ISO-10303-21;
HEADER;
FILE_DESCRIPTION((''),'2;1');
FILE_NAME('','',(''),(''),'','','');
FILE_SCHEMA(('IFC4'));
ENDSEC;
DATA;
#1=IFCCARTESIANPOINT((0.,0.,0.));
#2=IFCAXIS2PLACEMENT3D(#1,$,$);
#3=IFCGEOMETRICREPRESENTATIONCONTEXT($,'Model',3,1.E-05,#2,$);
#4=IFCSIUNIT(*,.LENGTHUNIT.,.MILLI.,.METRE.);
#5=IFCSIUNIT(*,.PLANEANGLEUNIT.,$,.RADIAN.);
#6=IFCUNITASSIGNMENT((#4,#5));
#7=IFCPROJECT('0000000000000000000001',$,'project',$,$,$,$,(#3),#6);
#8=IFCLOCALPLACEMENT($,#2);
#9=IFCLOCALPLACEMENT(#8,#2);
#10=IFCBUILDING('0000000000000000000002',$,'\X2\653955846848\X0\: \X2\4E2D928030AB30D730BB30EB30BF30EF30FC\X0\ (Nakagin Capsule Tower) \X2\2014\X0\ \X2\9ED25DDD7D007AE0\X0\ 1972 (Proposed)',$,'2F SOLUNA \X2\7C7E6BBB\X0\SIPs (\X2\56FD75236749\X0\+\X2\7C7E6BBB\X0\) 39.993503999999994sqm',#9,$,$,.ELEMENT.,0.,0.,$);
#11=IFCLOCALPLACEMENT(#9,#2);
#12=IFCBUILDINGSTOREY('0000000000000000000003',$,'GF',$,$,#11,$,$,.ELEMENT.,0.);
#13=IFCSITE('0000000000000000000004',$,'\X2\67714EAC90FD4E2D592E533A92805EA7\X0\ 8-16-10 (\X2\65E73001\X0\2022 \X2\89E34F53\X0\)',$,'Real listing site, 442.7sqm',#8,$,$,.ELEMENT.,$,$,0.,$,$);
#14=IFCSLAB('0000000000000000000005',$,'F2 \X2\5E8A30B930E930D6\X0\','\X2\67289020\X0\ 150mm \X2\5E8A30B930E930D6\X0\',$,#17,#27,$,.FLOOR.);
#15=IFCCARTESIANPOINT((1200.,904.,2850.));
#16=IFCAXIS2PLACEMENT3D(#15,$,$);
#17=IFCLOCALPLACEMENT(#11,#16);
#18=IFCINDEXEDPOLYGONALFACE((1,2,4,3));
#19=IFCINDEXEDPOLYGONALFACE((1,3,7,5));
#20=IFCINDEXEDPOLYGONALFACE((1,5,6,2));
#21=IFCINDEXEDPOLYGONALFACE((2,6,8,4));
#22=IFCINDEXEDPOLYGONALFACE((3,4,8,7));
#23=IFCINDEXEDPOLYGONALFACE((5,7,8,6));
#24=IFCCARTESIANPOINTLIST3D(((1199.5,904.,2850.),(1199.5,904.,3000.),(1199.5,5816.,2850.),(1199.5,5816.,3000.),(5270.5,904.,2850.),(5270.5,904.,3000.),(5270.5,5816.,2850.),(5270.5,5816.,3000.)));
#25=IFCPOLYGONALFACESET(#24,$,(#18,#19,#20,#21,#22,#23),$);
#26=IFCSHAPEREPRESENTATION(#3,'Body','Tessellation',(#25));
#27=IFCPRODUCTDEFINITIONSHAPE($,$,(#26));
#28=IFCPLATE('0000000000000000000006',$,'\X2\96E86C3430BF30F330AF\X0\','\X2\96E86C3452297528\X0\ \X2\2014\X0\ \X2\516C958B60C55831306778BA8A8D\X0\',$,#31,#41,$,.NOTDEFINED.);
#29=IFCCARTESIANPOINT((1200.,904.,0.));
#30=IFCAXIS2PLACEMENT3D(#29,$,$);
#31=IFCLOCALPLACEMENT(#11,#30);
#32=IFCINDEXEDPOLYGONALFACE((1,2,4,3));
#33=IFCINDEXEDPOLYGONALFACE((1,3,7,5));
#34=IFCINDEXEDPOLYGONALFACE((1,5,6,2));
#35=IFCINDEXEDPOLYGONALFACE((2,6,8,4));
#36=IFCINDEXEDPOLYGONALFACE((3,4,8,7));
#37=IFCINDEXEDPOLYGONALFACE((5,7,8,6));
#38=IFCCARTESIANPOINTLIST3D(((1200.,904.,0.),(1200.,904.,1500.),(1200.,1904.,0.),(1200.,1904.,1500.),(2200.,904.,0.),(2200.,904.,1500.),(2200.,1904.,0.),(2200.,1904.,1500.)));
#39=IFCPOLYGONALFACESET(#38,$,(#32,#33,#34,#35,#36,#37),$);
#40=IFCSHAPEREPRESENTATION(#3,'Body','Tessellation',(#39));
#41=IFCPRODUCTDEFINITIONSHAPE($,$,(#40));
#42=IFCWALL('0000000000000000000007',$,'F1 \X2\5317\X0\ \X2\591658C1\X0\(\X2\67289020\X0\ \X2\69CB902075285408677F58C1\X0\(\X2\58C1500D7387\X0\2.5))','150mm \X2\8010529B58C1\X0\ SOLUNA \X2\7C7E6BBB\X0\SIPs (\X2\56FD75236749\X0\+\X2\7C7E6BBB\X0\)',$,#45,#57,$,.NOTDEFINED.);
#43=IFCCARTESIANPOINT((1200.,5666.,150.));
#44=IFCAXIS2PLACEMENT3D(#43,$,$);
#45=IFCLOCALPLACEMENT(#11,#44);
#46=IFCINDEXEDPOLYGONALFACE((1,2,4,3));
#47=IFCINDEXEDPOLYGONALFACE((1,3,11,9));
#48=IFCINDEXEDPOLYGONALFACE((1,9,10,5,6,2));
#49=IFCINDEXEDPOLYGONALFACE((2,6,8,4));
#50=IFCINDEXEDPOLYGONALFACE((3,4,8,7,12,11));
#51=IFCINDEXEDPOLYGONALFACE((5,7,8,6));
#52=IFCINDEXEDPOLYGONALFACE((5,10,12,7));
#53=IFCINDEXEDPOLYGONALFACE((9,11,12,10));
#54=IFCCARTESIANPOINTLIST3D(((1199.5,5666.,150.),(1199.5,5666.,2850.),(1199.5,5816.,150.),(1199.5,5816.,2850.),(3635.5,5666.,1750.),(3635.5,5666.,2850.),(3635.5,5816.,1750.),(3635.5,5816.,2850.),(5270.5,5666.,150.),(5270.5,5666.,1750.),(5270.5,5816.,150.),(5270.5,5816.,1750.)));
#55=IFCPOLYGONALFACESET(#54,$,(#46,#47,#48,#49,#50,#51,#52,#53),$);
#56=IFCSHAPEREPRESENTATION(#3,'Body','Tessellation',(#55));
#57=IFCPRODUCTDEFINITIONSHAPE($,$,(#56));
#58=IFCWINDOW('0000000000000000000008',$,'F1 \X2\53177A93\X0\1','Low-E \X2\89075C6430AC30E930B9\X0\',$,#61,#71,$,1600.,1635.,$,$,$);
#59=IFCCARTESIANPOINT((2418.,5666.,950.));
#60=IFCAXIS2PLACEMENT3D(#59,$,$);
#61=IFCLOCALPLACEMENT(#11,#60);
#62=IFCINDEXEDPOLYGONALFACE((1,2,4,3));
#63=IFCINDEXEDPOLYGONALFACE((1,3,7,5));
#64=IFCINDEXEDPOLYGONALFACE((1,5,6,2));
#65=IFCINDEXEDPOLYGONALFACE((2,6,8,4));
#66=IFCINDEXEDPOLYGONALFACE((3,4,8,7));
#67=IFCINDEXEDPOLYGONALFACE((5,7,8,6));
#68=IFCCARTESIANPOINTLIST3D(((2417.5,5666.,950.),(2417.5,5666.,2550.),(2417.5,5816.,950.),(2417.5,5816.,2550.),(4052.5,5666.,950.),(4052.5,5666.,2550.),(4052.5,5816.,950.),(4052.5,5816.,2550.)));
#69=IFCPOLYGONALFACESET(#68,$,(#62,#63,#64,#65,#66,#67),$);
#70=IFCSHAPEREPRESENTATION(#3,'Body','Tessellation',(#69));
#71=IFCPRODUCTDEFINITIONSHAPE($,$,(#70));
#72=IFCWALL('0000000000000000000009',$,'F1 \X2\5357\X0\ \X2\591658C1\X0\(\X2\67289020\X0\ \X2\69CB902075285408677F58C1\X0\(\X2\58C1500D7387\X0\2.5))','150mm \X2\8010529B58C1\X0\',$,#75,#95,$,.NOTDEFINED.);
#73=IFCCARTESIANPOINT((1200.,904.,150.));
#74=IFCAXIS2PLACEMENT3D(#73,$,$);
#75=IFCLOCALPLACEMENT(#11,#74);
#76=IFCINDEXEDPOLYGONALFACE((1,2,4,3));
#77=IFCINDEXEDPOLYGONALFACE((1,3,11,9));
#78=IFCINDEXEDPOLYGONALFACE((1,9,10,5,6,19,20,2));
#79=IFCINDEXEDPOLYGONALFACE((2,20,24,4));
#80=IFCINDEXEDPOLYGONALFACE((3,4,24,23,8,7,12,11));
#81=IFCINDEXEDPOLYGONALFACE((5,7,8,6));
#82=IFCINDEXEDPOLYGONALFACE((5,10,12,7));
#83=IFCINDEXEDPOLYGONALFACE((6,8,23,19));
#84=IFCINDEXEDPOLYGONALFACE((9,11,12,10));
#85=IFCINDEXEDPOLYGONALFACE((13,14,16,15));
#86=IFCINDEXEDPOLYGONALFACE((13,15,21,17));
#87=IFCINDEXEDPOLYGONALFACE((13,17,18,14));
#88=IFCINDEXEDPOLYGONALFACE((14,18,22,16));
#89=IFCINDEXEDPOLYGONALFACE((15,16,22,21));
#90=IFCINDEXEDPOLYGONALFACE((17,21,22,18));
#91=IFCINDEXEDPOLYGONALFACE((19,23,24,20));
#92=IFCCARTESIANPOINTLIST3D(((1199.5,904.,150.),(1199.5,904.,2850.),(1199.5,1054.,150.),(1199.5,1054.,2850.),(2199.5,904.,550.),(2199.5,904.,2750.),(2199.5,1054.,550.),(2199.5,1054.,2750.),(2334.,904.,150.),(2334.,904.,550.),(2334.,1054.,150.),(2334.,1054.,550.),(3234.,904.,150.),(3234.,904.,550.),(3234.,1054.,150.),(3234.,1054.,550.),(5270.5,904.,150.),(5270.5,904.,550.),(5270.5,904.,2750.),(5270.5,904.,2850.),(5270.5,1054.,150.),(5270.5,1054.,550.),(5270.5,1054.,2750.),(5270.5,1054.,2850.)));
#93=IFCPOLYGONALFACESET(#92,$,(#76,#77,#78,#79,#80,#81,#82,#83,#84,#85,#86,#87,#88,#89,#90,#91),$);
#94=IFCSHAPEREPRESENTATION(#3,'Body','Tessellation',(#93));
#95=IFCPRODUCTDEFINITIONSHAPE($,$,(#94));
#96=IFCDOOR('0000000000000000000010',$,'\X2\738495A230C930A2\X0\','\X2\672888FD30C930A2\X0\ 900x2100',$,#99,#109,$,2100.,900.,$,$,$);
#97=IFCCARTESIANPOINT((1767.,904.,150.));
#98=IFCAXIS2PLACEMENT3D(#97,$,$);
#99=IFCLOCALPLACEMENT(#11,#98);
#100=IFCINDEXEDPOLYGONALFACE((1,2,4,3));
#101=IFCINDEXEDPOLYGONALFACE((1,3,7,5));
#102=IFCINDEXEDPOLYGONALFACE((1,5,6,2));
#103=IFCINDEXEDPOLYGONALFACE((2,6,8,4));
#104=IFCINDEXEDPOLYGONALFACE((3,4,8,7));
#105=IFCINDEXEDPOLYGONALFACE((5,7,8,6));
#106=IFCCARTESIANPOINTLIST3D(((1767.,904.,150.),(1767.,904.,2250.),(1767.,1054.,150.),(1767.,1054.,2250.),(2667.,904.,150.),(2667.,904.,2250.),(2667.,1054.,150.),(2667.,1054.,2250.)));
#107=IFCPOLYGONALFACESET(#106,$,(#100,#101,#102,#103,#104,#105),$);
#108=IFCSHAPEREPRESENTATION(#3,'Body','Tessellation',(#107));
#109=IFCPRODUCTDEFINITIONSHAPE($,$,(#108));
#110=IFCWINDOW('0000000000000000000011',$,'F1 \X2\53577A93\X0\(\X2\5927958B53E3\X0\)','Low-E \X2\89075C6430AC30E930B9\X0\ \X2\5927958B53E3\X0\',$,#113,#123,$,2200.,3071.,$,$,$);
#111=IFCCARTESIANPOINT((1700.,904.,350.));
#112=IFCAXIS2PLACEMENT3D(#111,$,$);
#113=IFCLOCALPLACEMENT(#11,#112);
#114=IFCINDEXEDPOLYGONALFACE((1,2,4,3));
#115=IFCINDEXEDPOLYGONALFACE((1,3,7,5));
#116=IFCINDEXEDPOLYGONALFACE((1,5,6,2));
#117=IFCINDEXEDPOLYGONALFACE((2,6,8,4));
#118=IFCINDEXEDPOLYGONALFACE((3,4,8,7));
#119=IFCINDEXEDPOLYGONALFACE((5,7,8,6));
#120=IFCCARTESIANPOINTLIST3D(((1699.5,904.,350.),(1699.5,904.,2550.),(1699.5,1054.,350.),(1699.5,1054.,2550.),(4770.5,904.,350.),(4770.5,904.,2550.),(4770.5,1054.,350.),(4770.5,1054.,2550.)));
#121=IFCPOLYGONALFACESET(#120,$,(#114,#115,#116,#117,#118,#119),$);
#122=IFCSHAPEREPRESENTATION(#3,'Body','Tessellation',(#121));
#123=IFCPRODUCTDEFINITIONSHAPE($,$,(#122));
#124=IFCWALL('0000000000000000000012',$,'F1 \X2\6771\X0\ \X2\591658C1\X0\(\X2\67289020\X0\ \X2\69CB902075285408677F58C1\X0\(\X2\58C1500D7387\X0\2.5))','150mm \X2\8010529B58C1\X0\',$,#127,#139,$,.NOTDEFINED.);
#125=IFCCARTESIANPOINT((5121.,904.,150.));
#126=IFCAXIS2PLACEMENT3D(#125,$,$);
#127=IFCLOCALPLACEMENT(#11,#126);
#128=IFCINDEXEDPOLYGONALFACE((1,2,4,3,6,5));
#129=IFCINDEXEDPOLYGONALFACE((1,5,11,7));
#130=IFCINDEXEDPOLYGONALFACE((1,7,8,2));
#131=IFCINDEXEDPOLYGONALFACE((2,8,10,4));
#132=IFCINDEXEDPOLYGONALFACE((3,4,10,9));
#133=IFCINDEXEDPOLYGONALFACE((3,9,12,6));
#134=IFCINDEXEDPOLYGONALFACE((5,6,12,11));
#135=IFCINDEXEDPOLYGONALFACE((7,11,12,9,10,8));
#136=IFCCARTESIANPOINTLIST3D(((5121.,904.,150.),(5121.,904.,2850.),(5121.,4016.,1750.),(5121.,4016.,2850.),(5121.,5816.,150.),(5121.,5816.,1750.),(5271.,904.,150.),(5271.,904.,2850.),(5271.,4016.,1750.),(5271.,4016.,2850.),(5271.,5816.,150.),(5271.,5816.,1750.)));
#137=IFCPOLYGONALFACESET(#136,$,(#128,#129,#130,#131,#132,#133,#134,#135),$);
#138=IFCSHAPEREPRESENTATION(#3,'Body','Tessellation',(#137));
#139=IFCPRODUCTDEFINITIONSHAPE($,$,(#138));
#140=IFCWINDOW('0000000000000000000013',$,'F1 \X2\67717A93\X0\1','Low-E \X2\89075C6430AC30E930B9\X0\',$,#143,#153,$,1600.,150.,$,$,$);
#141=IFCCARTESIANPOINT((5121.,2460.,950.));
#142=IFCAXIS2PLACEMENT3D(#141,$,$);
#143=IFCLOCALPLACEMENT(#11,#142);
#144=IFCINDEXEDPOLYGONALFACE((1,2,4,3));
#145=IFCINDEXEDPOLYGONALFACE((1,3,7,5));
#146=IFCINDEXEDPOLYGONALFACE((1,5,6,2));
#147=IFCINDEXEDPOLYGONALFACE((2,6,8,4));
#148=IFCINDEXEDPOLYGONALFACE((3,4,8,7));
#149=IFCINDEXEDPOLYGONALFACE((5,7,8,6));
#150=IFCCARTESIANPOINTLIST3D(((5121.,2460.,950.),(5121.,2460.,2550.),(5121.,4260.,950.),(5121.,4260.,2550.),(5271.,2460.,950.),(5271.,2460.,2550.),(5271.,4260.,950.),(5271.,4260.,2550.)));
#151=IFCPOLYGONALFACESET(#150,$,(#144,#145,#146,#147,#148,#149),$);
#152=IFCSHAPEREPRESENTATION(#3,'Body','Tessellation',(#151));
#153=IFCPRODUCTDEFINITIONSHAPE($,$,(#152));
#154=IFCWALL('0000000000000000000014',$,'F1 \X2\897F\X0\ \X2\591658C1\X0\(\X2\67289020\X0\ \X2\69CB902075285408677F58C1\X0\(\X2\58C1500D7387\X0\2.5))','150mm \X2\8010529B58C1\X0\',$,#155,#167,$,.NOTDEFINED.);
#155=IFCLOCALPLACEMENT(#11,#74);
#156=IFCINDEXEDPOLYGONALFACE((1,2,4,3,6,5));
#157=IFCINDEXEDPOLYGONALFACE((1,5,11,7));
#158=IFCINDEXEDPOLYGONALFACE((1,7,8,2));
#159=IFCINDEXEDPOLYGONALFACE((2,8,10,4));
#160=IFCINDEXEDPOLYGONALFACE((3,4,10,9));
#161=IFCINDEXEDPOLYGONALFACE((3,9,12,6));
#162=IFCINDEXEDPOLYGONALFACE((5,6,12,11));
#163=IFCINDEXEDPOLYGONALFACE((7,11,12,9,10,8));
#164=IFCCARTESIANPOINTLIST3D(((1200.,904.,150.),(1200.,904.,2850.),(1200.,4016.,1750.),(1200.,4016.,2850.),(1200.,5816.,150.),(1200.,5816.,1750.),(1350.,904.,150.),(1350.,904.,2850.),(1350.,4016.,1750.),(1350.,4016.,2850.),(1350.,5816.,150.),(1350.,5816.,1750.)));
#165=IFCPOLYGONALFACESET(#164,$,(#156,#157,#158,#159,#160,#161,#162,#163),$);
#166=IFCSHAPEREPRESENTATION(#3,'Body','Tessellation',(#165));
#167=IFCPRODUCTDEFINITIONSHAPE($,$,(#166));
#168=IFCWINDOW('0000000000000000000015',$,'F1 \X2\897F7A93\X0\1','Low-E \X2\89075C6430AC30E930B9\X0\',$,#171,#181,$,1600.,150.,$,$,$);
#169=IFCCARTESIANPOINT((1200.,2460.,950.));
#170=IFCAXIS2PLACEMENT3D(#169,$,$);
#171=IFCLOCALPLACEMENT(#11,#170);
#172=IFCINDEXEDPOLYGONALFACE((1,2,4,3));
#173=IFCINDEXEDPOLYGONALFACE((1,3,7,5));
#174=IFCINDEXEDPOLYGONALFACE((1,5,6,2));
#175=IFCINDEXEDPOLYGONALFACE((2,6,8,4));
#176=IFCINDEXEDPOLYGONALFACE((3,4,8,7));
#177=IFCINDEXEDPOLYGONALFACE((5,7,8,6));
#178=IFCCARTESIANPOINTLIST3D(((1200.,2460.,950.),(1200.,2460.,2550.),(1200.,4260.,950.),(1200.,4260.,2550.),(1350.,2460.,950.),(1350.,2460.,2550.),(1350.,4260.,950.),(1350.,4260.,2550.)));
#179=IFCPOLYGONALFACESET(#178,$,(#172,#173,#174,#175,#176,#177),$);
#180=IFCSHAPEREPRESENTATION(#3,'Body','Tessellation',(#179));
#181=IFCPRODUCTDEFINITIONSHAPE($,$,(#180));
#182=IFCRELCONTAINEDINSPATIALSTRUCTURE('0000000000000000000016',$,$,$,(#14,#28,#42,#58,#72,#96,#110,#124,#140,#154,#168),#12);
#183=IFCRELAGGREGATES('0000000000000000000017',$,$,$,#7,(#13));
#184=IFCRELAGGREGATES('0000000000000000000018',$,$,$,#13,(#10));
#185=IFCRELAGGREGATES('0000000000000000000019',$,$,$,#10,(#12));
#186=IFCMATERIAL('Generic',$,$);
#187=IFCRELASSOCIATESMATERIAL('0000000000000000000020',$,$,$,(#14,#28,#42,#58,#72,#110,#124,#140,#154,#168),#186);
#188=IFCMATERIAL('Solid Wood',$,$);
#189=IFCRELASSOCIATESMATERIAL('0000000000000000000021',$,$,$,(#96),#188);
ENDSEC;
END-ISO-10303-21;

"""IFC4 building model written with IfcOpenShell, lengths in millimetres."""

from ifc_helpers import new_model, si_unit, frame, frame_2d, origin, place, context, project, spatial, rectangle, extrude, material, element, fill, save


model = new_model("IFC4")

# Units and contexts
model_context = context("Model", 3, precision=1e-05, world=origin())
ifc_project = project(units=[si_unit("LENGTHUNIT", "METRE", prefix="MILLI"), si_unit("PLANEANGLEUNIT", "RADIAN")], contexts=[model_context])

# Site, building, storey
site_placement = place(None, origin())
site = spatial("IfcSite", under=ifc_project, at=site_placement, Name="東京都中央区銀座 8-16-10 (旧、2022 解体)", ObjectType="Real listing site, 442.7sqm", CompositionType="ELEMENT", RefElevation=0.0)
building_placement = place(site_placement, origin())
building = spatial("IfcBuilding", under=site, at=building_placement, Name="改善案: 中銀カプセルタワー (Nakagin Capsule Tower) — 黒川紀章 1972 (Proposed)", ObjectType="2F SOLUNA 籾殻SIPs (国産杉+籾殻) 39.993503999999994sqm", CompositionType="ELEMENT", ElevationOfRefHeight=0.0, ElevationOfTerrain=0.0)
storey_placement = place(building_placement, origin())
storey = spatial("IfcBuildingStorey", under=building, at=storey_placement, Name="GF", CompositionType="ELEMENT", Elevation=0.0)

# Slab
ifc_material_1 = material(Name="Generic")
slab_1_placement = place(storey_placement, frame((1200.0, 904.0, 2850.0)))
element("IfcSlab", 1, at=slab_1_placement, inside=storey, material=ifc_material_1, Name="F2 床スラブ", Description="木造 150mm 床スラブ", PredefinedType="FLOOR", context=model_context, shape_type="SweptSolid", body=[
    extrude(rectangle(XDim=4071.0, YDim=4912.0, at=frame_2d((2035.0, 2456.0))), frame((1200.0, 904.0, 2850.0)), (0.0, 0.0, 1.0), 150.0),
])

# Plate
plate_placement = place(storey_placement, frame((1200.0, 904.0, 0.0)))
element("IfcPlate", 2, at=plate_placement, inside=storey, material=ifc_material_1, Name="雨水タンク", Description="雨水利用 — 公開情報で確認", PredefinedType="NOTDEFINED", context=model_context, shape_type="SweptSolid", body=[
    extrude(rectangle(XDim=1000.0, YDim=1000.0, at=frame_2d((500.0, 500.0))), frame((1200.0, 904.0, 0.0)), (0.0, 0.0, 1.0), 1500.0),
])

# Wall, opening, window
wall_1_placement = place(storey_placement, frame((1200.0, 5666.0, 150.0)))
wall_1 = element("IfcWall", 3, at=wall_1_placement, inside=storey, material=ifc_material_1, Name="F1 北 外壁(木造 構造用合板壁(壁倍率2.5))", Description="150mm 耐力壁 SOLUNA 籾殻SIPs (国産杉+籾殻)", PredefinedType="NOTDEFINED", context=model_context, shape_type="SweptSolid", body=[
    extrude(rectangle(XDim=4071.0, YDim=150.0, at=frame_2d((2035.0, 75.0))), frame((1200.0, 5666.0, 150.0)), (0.0, 0.0, 1.0), 2700.0),
])
opening_1_placement = place(storey_placement, frame((2418.0, 5666.0, 950.0)))
opening_1 = element("IfcOpeningElement", 4, at=opening_1_placement, cuts=wall_1, PredefinedType="NOTDEFINED", context=model_context, shape_type="SweptSolid", body=[
    extrude(rectangle(XDim=1635.0, YDim=150.0, at=frame_2d((817.0, 75.0))), frame((2418.0, 5666.0, 950.0)), (0.0, 0.0, 1.0), 1600.0),
])
window_1_placement = place(storey_placement, frame((2418.0, 5666.0, 950.0)))
window_1 = element("IfcWindow", 5, at=window_1_placement, inside=storey, material=ifc_material_1, Name="F1 北窓1", Description="Low-E 複層ガラス", OverallHeight=1600.0, OverallWidth=1635.0, context=model_context, shape_type="SweptSolid", body=[
    extrude(rectangle(XDim=1635.0, YDim=150.0, at=frame_2d((817.0, 75.0))), frame((2418.0, 5666.0, 950.0)), (0.0, 0.0, 1.0), 1600.0),
])
fill(opening_1, window_1)

# Wall, openings, door, window
wall_2_placement = place(storey_placement, frame((1200.0, 904.0, 150.0)))
wall_2 = element("IfcWall", 6, at=wall_2_placement, inside=storey, material=ifc_material_1, Name="F1 南 外壁(木造 構造用合板壁(壁倍率2.5))", Description="150mm 耐力壁", PredefinedType="NOTDEFINED", context=model_context, shape_type="SweptSolid", body=[
    extrude(rectangle(XDim=4071.0, YDim=150.0, at=frame_2d((2035.0, 75.0))), frame((1200.0, 904.0, 150.0)), (0.0, 0.0, 1.0), 2700.0),
])
opening_2_placement = place(storey_placement, frame((1767.0, 904.0, 150.0)))
opening_2 = element("IfcOpeningElement", 7, at=opening_2_placement, cuts=wall_2, PredefinedType="NOTDEFINED", context=model_context, shape_type="SweptSolid", body=[
    extrude(rectangle(XDim=900.0, YDim=150.0, at=frame_2d((450.0, 75.0))), frame((1767.0, 904.0, 150.0)), (0.0, 0.0, 1.0), 2100.0),
])
opening_3_placement = place(storey_placement, frame((1700.0, 904.0, 350.0)))
opening_3 = element("IfcOpeningElement", 8, at=opening_3_placement, cuts=wall_2, PredefinedType="NOTDEFINED", context=model_context, shape_type="SweptSolid", body=[
    extrude(rectangle(XDim=3071.0, YDim=150.0, at=frame_2d((1535.0, 75.0))), frame((1700.0, 904.0, 350.0)), (0.0, 0.0, 1.0), 2200.0),
])
ifc_material_2 = material(Name="Solid Wood")
door_placement = place(storey_placement, frame((1767.0, 904.0, 150.0)))
door = element("IfcDoor", 9, at=door_placement, inside=storey, material=ifc_material_2, Name="玄関ドア", Description="木製ドア 900x2100", OverallHeight=2100.0, OverallWidth=900.0, context=model_context, shape_type="SweptSolid", body=[
    extrude(rectangle(XDim=900.0, YDim=150.0, at=frame_2d((450.0, 75.0))), frame((1767.0, 904.0, 150.0)), (0.0, 0.0, 1.0), 2100.0),
])
fill(opening_2, door)
window_2_placement = place(storey_placement, frame((1700.0, 904.0, 350.0)))
window_2 = element("IfcWindow", 10, at=window_2_placement, inside=storey, material=ifc_material_1, Name="F1 南窓(大開口)", Description="Low-E 複層ガラス 大開口", OverallHeight=2200.0, OverallWidth=3071.0, context=model_context, shape_type="SweptSolid", body=[
    extrude(rectangle(XDim=3071.0, YDim=150.0, at=frame_2d((1535.0, 75.0))), frame((1700.0, 904.0, 350.0)), (0.0, 0.0, 1.0), 2200.0),
])
fill(opening_3, window_2)

# Walls, openings, windows
wall_3_placement = place(storey_placement, frame((5121.0, 904.0, 150.0)))
wall_3 = element("IfcWall", 11, at=wall_3_placement, inside=storey, material=ifc_material_1, Name="F1 東 外壁(木造 構造用合板壁(壁倍率2.5))", Description="150mm 耐力壁", PredefinedType="NOTDEFINED", context=model_context, shape_type="SweptSolid", body=[
    extrude(rectangle(XDim=150.0, YDim=4912.0, at=frame_2d((75.0, 2456.0))), frame((5121.0, 904.0, 150.0)), (0.0, 0.0, 1.0), 2700.0),
])
opening_4_placement = place(storey_placement, frame((5121.0, 2460.0, 950.0)))
opening_4 = element("IfcOpeningElement", 12, at=opening_4_placement, cuts=wall_3, PredefinedType="NOTDEFINED", context=model_context, shape_type="SweptSolid", body=[
    extrude(rectangle(XDim=150.0, YDim=1800.0, at=frame_2d((75.0, 900.0))), frame((5121.0, 2460.0, 950.0)), (0.0, 0.0, 1.0), 1600.0),
])
window_3_placement = place(storey_placement, frame((5121.0, 2460.0, 950.0)))
window_3 = element("IfcWindow", 13, at=window_3_placement, inside=storey, material=ifc_material_1, Name="F1 東窓1", Description="Low-E 複層ガラス", OverallHeight=1600.0, OverallWidth=150.0, context=model_context, shape_type="SweptSolid", body=[
    extrude(rectangle(XDim=150.0, YDim=1800.0, at=frame_2d((75.0, 900.0))), frame((5121.0, 2460.0, 950.0)), (0.0, 0.0, 1.0), 1600.0),
])
fill(opening_4, window_3)
wall_4_placement = place(storey_placement, frame((1200.0, 904.0, 150.0)))
wall_4 = element("IfcWall", 14, at=wall_4_placement, inside=storey, material=ifc_material_1, Name="F1 西 外壁(木造 構造用合板壁(壁倍率2.5))", Description="150mm 耐力壁", PredefinedType="NOTDEFINED", context=model_context, shape_type="SweptSolid", body=[
    extrude(rectangle(XDim=150.0, YDim=4912.0, at=frame_2d((75.0, 2456.0))), frame((1200.0, 904.0, 150.0)), (0.0, 0.0, 1.0), 2700.0),
])
opening_5_placement = place(storey_placement, frame((1200.0, 2460.0, 950.0)))
opening_5 = element("IfcOpeningElement", 15, at=opening_5_placement, cuts=wall_4, PredefinedType="NOTDEFINED", context=model_context, shape_type="SweptSolid", body=[
    extrude(rectangle(XDim=150.0, YDim=1800.0, at=frame_2d((75.0, 900.0))), frame((1200.0, 2460.0, 950.0)), (0.0, 0.0, 1.0), 1600.0),
])
window_4_placement = place(storey_placement, frame((1200.0, 2460.0, 950.0)))
window_4 = element("IfcWindow", 16, at=window_4_placement, inside=storey, material=ifc_material_1, Name="F1 西窓1", Description="Low-E 複層ガラス", OverallHeight=1600.0, OverallWidth=150.0, context=model_context, shape_type="SweptSolid", body=[
    extrude(rectangle(XDim=150.0, YDim=1800.0, at=frame_2d((75.0, 900.0))), frame((1200.0, 2460.0, 950.0)), (0.0, 0.0, 1.0), 1600.0),
])
fill(opening_5, window_4)

save(model, "model.ifc")
